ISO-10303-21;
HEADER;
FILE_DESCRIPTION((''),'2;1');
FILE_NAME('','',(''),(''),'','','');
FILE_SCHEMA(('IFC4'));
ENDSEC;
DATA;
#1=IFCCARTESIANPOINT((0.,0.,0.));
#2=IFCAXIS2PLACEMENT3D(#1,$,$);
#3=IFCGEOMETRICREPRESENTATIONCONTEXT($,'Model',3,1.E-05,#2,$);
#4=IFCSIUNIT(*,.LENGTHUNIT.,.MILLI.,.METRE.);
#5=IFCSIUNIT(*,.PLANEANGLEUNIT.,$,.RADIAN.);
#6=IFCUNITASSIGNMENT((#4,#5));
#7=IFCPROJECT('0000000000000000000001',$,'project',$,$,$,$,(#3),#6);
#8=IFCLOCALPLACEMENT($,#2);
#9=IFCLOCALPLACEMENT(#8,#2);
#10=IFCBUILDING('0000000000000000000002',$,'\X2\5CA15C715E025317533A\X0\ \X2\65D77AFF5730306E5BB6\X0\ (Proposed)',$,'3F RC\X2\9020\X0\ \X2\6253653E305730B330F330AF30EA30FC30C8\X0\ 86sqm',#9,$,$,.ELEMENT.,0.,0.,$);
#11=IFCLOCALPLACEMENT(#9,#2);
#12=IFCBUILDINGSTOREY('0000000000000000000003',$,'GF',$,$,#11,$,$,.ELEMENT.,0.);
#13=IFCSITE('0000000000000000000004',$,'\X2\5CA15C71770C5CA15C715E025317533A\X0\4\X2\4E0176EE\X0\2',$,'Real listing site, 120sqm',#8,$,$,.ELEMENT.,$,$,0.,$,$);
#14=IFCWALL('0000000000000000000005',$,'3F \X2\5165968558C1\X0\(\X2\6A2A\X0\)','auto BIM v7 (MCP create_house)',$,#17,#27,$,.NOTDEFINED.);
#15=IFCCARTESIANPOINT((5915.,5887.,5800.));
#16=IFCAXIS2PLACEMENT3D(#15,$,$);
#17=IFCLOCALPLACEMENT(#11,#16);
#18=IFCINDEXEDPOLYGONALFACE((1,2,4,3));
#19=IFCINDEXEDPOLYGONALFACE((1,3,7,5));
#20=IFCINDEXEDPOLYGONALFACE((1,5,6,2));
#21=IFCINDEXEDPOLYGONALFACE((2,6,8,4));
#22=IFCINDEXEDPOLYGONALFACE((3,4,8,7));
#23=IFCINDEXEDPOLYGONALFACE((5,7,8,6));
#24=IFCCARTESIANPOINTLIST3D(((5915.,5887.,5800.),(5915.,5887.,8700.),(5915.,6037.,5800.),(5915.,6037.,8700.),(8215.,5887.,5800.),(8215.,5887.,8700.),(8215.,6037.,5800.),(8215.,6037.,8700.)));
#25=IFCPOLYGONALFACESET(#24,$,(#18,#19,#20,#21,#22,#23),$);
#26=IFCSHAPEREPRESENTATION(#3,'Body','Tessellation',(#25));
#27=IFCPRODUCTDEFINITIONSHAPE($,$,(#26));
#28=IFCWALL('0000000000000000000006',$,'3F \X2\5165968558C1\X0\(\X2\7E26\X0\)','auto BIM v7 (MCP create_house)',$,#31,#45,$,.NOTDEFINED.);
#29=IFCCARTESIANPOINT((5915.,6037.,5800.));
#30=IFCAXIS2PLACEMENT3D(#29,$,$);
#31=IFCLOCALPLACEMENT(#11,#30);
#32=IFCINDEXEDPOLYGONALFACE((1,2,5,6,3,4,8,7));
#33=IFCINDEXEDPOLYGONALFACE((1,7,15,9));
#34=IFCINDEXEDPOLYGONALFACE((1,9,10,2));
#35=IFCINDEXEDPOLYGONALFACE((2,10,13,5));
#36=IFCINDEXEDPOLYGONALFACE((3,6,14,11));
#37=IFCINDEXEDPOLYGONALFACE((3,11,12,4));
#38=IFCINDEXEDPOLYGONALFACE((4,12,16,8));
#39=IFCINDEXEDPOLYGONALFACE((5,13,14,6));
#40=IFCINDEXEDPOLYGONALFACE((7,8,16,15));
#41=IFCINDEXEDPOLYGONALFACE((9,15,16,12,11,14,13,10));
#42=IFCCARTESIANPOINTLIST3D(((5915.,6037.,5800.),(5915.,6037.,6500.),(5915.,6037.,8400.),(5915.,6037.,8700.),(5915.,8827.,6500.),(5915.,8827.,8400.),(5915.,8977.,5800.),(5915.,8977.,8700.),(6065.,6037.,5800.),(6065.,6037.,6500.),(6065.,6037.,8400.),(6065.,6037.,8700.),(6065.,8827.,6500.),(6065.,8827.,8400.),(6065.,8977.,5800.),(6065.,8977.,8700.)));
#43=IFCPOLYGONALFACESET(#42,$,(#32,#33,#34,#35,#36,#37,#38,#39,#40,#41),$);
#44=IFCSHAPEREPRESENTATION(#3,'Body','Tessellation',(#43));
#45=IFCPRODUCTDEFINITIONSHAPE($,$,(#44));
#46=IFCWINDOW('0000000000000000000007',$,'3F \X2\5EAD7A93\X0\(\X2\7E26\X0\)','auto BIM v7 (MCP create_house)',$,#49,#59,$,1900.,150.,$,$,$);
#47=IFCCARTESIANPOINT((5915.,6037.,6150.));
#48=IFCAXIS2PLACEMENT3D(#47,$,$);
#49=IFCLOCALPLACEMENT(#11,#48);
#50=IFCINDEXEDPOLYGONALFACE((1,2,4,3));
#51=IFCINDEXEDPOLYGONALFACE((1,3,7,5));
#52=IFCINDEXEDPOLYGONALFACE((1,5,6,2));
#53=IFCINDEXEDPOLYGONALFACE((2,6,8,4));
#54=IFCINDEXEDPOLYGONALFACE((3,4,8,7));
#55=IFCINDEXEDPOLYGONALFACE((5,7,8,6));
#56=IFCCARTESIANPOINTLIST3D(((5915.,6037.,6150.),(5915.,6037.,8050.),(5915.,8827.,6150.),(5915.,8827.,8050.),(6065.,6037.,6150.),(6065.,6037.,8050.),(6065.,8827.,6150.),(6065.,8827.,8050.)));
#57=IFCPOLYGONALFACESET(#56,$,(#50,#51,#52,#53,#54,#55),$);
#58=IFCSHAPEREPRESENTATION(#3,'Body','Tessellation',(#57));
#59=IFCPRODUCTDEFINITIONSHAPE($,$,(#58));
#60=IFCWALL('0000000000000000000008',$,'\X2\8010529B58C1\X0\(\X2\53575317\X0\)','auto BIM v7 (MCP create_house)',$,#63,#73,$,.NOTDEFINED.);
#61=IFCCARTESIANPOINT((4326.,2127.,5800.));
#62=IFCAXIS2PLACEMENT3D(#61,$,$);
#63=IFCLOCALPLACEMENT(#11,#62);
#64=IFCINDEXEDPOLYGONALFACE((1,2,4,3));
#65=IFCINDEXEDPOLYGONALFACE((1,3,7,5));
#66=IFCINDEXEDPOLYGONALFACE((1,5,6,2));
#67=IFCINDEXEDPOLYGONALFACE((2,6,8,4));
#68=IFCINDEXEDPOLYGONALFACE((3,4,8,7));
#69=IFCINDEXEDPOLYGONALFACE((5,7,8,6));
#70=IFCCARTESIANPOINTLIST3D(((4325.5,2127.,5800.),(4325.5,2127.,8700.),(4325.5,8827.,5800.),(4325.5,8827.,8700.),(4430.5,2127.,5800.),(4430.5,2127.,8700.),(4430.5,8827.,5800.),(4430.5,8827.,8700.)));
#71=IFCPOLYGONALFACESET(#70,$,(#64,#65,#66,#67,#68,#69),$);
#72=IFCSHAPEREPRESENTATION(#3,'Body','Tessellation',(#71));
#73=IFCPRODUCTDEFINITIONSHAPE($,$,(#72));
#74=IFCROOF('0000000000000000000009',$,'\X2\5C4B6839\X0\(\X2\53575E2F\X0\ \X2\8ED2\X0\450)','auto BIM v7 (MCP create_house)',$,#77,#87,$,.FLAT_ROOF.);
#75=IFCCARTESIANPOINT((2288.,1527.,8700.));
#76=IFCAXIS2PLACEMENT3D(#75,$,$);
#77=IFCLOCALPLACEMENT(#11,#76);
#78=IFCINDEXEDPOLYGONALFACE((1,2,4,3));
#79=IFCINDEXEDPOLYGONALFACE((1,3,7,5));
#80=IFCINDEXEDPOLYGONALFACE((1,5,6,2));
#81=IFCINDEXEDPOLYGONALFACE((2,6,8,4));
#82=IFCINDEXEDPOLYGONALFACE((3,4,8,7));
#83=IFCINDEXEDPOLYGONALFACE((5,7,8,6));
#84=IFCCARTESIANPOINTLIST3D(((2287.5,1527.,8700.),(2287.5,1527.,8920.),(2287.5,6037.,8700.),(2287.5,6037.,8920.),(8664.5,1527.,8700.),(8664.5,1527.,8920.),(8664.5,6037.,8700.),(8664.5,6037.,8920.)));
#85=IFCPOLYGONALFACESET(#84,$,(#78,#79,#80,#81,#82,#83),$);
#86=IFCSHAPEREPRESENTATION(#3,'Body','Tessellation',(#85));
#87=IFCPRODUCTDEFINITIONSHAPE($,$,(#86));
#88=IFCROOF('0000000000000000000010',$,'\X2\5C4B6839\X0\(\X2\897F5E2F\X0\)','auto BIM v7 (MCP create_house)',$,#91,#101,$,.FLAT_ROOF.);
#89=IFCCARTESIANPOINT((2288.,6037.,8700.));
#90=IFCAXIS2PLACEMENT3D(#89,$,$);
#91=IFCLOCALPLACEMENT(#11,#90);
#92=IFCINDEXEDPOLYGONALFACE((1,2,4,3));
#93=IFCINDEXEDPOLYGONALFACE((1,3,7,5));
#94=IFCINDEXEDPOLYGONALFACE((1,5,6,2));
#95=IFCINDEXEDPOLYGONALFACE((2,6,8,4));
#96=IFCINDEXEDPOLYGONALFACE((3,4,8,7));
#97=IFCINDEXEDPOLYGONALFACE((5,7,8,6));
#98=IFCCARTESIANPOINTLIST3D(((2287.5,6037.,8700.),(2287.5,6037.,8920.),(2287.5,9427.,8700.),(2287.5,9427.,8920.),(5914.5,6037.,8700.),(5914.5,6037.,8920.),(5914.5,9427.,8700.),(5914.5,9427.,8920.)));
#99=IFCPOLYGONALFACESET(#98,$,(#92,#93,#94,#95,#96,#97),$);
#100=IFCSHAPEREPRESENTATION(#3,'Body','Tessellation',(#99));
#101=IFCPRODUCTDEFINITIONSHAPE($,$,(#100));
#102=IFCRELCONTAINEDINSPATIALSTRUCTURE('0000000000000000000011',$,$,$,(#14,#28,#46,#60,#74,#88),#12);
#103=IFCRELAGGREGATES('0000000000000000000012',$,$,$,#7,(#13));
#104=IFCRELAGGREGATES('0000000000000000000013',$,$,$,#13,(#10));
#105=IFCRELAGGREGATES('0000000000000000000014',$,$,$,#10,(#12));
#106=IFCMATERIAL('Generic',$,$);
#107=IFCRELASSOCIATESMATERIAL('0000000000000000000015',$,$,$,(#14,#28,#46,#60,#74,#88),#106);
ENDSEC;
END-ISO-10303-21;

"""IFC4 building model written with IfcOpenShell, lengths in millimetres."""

from ifc_helpers import new_model, si_unit, frame, frame_2d, origin, place, context, project, spatial, rectangle, extrude, material, element, fill, save


model = new_model("IFC4")

# Units and contexts
model_context = context("Model", 3, precision=1e-05, world=origin())
ifc_project = project(units=[si_unit("LENGTHUNIT", "METRE", prefix="MILLI"), si_unit("PLANEANGLEUNIT", "RADIAN")], contexts=[model_context])

# Site, building, storey
site_placement = place(None, origin())
site = spatial("IfcSite", under=ifc_project, at=site_placement, Name="岡山県岡山市北区4丁目2", ObjectType="Real listing site, 120sqm", CompositionType="ELEMENT", RefElevation=0.0)
building_placement = place(site_placement, origin())
building = spatial("IfcBuilding", under=site, at=building_placement, Name="岡山市北区 旗竿地の家 (Proposed)", ObjectType="3F RC造 打放しコンクリート 86sqm", CompositionType="ELEMENT", ElevationOfRefHeight=0.0, ElevationOfTerrain=0.0)
storey_placement = place(building_placement, origin())
storey = spatial("IfcBuildingStorey", under=building, at=storey_placement, Name="GF", CompositionType="ELEMENT", Elevation=0.0)

# Shared definitions
ifc_material = material(Name="Generic")

# Wall
wall_1_placement = place(storey_placement, frame((5915.0, 5887.0, 5800.0)))
element("IfcWall", 1, at=wall_1_placement, inside=storey, material=ifc_material, Name="3F 入隅壁(横)", Description="auto BIM v7 (MCP create_house)", PredefinedType="NOTDEFINED", context=model_context, shape_type="SweptSolid", body=[
    extrude(rectangle(XDim=2300.0, YDim=150.0, at=frame_2d((1150.0, 75.0))), frame((5915.0, 5887.0, 5800.0)), (0.0, 0.0, 1.0), 2900.0),
])

# Wall, opening, window
wall_2_placement = place(storey_placement, frame((5915.0, 6037.0, 5800.0)))
wall_2 = element("IfcWall", 2, at=wall_2_placement, inside=storey, material=ifc_material, Name="3F 入隅壁(縦)", Description="auto BIM v7 (MCP create_house)", PredefinedType="NOTDEFINED", context=model_context, shape_type="SweptSolid", body=[
    extrude(rectangle(XDim=150.0, YDim=2940.0, at=frame_2d((75.0, 1470.0))), frame((5915.0, 6037.0, 5800.0)), (0.0, 0.0, 1.0), 2900.0),
])
opening_1_placement = place(storey_placement, frame((5915.0, 6037.0, 6150.0)))
opening_1 = element("IfcOpeningElement", 3, at=opening_1_placement, cuts=wall_2, PredefinedType="NOTDEFINED", context=model_context, shape_type="SweptSolid", body=[
    extrude(rectangle(XDim=150.0, YDim=2790.0, at=frame_2d((75.0, 1395.0))), frame((5915.0, 6037.0, 6150.0)), (0.0, 0.0, 1.0), 1900.0),
])
window_1_placement = place(storey_placement, frame((5915.0, 6037.0, 6150.0)))
window_1 = element("IfcWindow", 4, at=window_1_placement, inside=storey, material=ifc_material, Name="3F 庭窓(縦)", Description="auto BIM v7 (MCP create_house)", OverallHeight=1900.0, OverallWidth=150.0, context=model_context, shape_type="SweptSolid", body=[
    extrude(rectangle(XDim=150.0, YDim=2790.0, at=frame_2d((75.0, 1395.0))), frame((5915.0, 6037.0, 6150.0)), (0.0, 0.0, 1.0), 1900.0),
])
fill(opening_1, window_1)

# Wall
wall_3_placement = place(storey_placement, frame((4326.0, 2127.0, 5800.0)))
element("IfcWall", 5, at=wall_3_placement, inside=storey, material=ifc_material, Name="耐力壁(南北)", Description="auto BIM v7 (MCP create_house)", PredefinedType="NOTDEFINED", context=model_context, shape_type="SweptSolid", body=[
    extrude(rectangle(XDim=105.0, YDim=6700.0, at=frame_2d((52.0, 3350.0))), frame((4326.0, 2127.0, 5800.0)), (0.0, 0.0, 1.0), 2900.0),
])

# Roofs
roof_1_placement = place(storey_placement, frame((2288.0, 1527.0, 8700.0)))
element("IfcRoof", 6, at=roof_1_placement, inside=storey, material=ifc_material, Name="屋根(南帯 軒450)", Description="auto BIM v7 (MCP create_house)", PredefinedType="FLAT_ROOF", context=model_context, shape_type="SweptSolid", body=[
    extrude(rectangle(XDim=6377.0, YDim=4510.0, at=frame_2d((3188.0, 2255.0))), frame((2288.0, 1527.0, 8700.0)), (0.0, 0.0, 1.0), 220.0),
])
roof_2_placement = place(storey_placement, frame((2288.0, 6037.0, 8700.0)))
element("IfcRoof", 7, at=roof_2_placement, inside=storey, material=ifc_material, Name="屋根(西帯)", Description="auto BIM v7 (MCP create_house)", PredefinedType="FLAT_ROOF", context=model_context, shape_type="SweptSolid", body=[
    extrude(rectangle(XDim=3627.0, YDim=3390.0, at=frame_2d((1813.0, 1695.0))), frame((2288.0, 6037.0, 8700.0)), (0.0, 0.0, 1.0), 220.0),
])

save(model, "model.ifc")
